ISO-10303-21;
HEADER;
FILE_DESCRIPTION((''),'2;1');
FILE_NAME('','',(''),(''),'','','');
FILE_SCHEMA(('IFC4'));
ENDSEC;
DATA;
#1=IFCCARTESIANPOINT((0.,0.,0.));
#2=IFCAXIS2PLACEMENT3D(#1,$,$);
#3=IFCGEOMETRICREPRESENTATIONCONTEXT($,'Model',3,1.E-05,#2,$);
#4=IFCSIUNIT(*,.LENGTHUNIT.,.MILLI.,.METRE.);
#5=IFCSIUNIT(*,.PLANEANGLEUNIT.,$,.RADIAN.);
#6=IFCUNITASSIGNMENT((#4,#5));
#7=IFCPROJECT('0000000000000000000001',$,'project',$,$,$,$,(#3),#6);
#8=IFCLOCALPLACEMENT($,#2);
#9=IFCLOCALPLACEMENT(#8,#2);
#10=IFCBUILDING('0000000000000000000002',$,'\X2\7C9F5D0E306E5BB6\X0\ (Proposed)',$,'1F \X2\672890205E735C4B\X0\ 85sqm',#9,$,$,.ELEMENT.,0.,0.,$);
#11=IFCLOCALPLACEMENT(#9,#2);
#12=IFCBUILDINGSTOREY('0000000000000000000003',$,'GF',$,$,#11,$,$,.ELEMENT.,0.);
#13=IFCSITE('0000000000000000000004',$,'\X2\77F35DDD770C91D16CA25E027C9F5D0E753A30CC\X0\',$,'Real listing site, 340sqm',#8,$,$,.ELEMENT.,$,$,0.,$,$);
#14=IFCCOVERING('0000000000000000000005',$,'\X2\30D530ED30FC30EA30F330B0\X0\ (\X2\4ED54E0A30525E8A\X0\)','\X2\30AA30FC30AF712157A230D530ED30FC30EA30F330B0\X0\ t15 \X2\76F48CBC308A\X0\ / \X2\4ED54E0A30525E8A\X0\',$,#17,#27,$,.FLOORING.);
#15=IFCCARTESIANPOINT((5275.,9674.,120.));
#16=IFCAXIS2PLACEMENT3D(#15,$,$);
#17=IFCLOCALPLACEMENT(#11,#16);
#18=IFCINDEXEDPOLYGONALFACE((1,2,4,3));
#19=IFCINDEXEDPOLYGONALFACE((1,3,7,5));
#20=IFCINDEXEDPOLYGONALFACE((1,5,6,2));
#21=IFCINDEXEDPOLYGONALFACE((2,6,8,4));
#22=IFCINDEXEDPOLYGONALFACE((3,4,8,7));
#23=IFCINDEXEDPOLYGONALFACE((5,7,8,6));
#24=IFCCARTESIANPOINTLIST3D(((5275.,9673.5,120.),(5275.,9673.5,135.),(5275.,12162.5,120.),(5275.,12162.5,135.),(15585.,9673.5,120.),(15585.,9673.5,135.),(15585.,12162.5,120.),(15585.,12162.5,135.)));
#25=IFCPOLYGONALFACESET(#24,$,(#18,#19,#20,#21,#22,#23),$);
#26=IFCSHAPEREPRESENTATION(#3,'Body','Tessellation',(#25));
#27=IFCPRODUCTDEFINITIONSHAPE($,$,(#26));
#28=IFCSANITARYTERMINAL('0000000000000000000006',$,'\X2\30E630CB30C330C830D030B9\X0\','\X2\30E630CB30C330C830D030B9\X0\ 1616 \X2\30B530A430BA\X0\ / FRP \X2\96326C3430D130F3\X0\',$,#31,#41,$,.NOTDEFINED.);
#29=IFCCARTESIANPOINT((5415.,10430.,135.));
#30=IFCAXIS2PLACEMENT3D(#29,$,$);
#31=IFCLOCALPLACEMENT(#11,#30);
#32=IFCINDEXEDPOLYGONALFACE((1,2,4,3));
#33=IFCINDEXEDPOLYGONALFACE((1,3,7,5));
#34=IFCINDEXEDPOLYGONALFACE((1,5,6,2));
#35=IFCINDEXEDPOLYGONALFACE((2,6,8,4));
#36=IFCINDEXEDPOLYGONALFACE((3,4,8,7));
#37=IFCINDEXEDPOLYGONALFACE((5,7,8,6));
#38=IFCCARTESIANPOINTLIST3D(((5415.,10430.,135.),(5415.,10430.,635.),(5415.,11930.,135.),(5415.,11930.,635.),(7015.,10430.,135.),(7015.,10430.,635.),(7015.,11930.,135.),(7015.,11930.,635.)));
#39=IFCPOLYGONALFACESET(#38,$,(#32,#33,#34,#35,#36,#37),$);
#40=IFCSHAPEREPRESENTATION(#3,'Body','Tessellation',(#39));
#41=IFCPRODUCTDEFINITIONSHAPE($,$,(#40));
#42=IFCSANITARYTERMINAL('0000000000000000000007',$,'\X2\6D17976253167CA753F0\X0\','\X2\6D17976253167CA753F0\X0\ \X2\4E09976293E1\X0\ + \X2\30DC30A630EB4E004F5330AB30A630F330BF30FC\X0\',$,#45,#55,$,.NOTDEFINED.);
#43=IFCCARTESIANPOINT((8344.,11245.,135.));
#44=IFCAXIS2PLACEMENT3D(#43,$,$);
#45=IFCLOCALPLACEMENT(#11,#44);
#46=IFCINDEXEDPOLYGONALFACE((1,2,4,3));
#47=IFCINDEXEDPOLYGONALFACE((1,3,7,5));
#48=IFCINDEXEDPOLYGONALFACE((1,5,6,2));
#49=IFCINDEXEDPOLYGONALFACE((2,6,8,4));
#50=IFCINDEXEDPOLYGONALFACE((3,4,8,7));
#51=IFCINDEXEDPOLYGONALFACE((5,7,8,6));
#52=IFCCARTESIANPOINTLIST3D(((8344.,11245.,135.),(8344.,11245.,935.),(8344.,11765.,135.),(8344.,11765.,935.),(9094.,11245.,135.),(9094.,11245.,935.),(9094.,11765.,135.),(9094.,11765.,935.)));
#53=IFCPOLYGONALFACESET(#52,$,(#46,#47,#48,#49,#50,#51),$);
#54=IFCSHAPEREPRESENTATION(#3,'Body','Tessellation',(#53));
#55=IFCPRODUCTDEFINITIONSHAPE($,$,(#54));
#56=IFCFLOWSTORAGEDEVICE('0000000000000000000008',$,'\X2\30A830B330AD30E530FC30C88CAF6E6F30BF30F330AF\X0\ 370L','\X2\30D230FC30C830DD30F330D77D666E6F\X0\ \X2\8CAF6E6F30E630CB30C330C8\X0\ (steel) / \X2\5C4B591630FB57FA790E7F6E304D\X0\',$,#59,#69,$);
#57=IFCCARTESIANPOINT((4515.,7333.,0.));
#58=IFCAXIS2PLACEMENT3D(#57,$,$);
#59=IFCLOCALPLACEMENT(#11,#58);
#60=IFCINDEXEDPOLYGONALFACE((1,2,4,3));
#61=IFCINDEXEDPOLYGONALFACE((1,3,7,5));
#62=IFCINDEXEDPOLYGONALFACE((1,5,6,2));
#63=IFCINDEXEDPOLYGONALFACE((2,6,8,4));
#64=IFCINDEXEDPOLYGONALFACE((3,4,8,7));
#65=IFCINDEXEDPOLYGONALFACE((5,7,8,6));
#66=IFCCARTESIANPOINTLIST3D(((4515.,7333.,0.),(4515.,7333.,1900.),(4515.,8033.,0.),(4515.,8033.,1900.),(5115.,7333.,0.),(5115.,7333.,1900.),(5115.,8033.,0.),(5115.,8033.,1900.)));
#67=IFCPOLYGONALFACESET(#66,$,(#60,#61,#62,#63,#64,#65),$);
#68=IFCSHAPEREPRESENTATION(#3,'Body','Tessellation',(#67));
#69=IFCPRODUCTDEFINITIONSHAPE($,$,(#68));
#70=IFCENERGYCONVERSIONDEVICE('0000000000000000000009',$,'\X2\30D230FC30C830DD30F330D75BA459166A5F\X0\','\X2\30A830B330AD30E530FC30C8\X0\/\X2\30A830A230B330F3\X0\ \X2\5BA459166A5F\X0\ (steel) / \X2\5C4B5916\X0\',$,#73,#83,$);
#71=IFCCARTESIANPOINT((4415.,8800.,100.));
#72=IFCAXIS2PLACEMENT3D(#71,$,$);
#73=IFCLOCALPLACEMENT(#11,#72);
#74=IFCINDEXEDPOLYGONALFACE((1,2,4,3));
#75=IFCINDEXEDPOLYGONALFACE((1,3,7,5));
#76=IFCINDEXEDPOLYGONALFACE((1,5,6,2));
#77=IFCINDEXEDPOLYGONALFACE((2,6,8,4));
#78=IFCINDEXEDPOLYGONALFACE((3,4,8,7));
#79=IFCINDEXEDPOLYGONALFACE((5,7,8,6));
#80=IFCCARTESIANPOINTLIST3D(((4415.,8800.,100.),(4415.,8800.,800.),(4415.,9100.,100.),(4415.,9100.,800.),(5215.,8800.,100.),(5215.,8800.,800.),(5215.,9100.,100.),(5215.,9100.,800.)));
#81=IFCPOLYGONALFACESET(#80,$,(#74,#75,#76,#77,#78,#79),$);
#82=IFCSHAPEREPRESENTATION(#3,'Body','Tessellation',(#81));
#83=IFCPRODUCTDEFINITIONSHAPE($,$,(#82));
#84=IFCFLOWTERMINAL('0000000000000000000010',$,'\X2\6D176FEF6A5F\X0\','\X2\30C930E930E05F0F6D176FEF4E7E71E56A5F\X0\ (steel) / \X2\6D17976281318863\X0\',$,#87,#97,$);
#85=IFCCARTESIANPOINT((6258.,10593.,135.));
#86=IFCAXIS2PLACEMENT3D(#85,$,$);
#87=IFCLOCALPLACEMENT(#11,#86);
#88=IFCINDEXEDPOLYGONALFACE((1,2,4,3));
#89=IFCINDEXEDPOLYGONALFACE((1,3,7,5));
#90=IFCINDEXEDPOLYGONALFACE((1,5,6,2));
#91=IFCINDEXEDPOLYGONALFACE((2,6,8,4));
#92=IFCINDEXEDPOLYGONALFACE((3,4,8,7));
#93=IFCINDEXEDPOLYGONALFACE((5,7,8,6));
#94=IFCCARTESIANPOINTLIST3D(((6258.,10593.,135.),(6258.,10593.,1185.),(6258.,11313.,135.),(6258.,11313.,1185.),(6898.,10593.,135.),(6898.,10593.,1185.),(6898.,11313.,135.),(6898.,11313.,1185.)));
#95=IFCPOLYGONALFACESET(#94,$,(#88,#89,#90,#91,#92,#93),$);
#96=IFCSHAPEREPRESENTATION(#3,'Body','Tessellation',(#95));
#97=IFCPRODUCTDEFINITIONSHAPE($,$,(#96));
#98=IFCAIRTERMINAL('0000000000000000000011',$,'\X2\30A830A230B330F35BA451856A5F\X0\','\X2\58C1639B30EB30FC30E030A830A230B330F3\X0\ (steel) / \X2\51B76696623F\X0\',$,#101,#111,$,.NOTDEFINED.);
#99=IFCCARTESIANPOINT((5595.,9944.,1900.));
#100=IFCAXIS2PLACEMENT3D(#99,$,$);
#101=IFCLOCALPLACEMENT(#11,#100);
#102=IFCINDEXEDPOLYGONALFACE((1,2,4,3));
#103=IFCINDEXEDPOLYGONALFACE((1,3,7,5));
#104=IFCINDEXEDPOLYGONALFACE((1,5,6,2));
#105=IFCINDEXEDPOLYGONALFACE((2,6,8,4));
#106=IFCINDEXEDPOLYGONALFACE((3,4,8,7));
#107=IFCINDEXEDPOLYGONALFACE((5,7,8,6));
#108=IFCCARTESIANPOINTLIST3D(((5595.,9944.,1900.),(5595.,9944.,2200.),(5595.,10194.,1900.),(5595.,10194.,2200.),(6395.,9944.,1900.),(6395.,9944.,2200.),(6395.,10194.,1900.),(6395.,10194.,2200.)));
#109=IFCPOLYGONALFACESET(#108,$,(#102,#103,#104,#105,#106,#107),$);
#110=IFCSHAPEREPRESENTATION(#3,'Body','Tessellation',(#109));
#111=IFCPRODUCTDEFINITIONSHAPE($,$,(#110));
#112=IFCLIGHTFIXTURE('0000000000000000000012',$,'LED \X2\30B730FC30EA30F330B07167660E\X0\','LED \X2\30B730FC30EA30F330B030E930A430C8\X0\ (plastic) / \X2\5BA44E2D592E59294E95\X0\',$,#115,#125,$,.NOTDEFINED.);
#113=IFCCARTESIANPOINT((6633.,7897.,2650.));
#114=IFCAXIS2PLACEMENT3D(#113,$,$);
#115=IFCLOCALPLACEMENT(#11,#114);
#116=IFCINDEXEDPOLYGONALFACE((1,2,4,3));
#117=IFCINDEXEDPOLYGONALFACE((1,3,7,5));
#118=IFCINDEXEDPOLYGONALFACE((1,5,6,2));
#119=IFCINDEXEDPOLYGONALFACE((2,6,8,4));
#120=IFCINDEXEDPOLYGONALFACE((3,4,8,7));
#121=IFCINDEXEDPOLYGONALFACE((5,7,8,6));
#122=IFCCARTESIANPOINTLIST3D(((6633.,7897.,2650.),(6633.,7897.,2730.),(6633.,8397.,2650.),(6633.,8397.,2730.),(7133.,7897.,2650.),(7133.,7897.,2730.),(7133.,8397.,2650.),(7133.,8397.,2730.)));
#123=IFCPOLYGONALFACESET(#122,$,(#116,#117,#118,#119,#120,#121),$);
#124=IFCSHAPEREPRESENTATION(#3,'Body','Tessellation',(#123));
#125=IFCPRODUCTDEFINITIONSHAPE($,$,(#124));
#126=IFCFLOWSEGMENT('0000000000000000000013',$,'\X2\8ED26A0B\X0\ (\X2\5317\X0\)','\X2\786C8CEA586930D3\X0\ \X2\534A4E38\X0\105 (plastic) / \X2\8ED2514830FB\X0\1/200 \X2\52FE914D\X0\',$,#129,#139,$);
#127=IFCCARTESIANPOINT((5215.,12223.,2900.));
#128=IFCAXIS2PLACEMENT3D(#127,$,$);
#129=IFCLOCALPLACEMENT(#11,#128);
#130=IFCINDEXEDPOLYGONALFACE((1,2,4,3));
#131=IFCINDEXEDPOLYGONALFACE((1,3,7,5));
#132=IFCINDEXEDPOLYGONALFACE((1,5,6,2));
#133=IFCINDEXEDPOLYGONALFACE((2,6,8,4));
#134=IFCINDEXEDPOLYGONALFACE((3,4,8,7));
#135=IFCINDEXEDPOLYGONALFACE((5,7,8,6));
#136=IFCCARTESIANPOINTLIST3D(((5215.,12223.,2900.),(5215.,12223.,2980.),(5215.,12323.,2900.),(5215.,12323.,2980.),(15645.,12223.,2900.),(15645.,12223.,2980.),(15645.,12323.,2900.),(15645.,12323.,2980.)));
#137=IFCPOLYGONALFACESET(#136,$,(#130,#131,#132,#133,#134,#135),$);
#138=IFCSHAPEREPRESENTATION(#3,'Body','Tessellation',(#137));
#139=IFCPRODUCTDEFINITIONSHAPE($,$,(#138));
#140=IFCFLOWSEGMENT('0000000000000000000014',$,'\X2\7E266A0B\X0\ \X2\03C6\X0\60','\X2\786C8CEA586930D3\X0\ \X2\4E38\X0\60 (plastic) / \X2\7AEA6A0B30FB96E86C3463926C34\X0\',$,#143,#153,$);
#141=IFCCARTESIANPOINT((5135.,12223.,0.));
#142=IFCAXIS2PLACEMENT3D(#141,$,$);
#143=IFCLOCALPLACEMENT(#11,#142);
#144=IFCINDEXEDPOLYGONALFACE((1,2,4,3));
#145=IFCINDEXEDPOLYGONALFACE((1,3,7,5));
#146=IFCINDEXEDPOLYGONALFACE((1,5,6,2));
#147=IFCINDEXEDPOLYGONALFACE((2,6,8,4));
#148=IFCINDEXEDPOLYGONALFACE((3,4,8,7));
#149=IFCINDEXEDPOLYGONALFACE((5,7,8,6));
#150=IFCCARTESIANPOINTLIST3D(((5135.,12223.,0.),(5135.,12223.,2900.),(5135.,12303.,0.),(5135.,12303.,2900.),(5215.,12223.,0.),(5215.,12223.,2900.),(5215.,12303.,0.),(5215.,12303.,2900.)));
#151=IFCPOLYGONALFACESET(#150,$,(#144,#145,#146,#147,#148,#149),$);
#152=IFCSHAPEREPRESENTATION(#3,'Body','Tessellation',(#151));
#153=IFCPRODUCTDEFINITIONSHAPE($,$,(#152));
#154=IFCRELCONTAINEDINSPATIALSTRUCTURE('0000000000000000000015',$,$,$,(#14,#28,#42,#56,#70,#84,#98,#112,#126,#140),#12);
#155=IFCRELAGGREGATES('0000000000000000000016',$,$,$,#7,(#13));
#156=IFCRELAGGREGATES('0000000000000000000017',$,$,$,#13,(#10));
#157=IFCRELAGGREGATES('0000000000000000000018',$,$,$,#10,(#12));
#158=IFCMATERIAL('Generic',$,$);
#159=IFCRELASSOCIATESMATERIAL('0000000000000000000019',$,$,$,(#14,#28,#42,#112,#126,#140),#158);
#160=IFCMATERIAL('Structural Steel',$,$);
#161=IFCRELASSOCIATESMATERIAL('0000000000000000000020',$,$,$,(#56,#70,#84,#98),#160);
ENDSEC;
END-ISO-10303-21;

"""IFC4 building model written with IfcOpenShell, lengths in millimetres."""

from ifc_helpers import new_model, si_unit, frame, frame_2d, origin, place, context, project, spatial, rectangle, extrude, material, element, save


model = new_model("IFC4")

# Units and contexts
model_context = context("Model", 3, precision=1e-05, world=origin())
ifc_project = project(units=[si_unit("LENGTHUNIT", "METRE", prefix="MILLI"), si_unit("PLANEANGLEUNIT", "RADIAN")], contexts=[model_context])

# Site, building, storey
site_placement = place(None, origin())
site = spatial("IfcSite", under=ifc_project, at=site_placement, Name="石川県金沢市粟崎町ヌ", ObjectType="Real listing site, 340sqm", CompositionType="ELEMENT", RefElevation=0.0)
building_placement = place(site_placement, origin())
building = spatial("IfcBuilding", under=site, at=building_placement, Name="粟崎の家 (Proposed)", ObjectType="1F 木造平屋 85sqm", CompositionType="ELEMENT", ElevationOfRefHeight=0.0, ElevationOfTerrain=0.0)
storey_placement = place(building_placement, origin())
storey = spatial("IfcBuildingStorey", under=building, at=storey_placement, Name="GF", CompositionType="ELEMENT", Elevation=0.0)

# Shared definitions
ifc_material_1 = material(Name="Structural Steel")

# Covering
ifc_material_2 = material(Name="Generic")
covering_1_placement = place(storey_placement, frame((5275.0, 9674.0, 120.0)))
element("IfcCovering", 1, at=covering_1_placement, inside=storey, material=ifc_material_2, Name="フローリング (仕上げ床)", Description="オーク無垢フローリング t15 直貼り / 仕上げ床", PredefinedType="FLOORING", context=model_context, shape_type="SweptSolid", body=[
    extrude(rectangle(XDim=10310.0, YDim=2489.0, at=frame_2d((5155.0, 1244.0))), frame((5275.0, 9674.0, 120.0)), (0.0, 0.0, 1.0), 15.0),
])

# Sanitary terminals
sanitary_terminal_1_placement = place(storey_placement, frame((5415.0, 10430.0, 135.0)))
element("IfcSanitaryTerminal", 2, at=sanitary_terminal_1_placement, inside=storey, material=ifc_material_2, Name="ユニットバス", Description="ユニットバス 1616 サイズ / FRP 防水パン", PredefinedType="NOTDEFINED", context=model_context, shape_type="SweptSolid", body=[
    extrude(rectangle(XDim=1600.0, YDim=1500.0, at=frame_2d((800.0, 750.0))), frame((5415.0, 10430.0, 135.0)), (0.0, 0.0, 1.0), 500.0),
])
sanitary_terminal_2_placement = place(storey_placement, frame((8344.0, 11245.0, 135.0)))
element("IfcSanitaryTerminal", 3, at=sanitary_terminal_2_placement, inside=storey, material=ifc_material_2, Name="洗面化粧台", Description="洗面化粧台 三面鏡 + ボウル一体カウンター", PredefinedType="NOTDEFINED", context=model_context, shape_type="SweptSolid", body=[
    extrude(rectangle(XDim=750.0, YDim=520.0, at=frame_2d((375.0, 260.0))), frame((8344.0, 11245.0, 135.0)), (0.0, 0.0, 1.0), 800.0),
])

# Flow storage device
flow_storage_device_placement = place(storey_placement, frame((4515.0, 7333.0, 0.0)))
element("IfcFlowStorageDevice", 4, at=flow_storage_device_placement, inside=storey, material=ifc_material_1, Name="エコキュート貯湯タンク 370L", Description="ヒートポンプ給湯 貯湯ユニット (steel) / 屋外・基礎置き", context=model_context, shape_type="SweptSolid", body=[
    extrude(rectangle(XDim=600.0, YDim=700.0, at=frame_2d((300.0, 350.0))), frame((4515.0, 7333.0, 0.0)), (0.0, 0.0, 1.0), 1900.0),
])

# Energy conversion device
energy_conversion_device_placement = place(storey_placement, frame((4415.0, 8800.0, 100.0)))
element("IfcEnergyConversionDevice", 5, at=energy_conversion_device_placement, inside=storey, material=ifc_material_1, Name="ヒートポンプ室外機", Description="エコキュート/エアコン 室外機 (steel) / 屋外", context=model_context, shape_type="SweptSolid", body=[
    extrude(rectangle(XDim=800.0, YDim=300.0, at=frame_2d((400.0, 150.0))), frame((4415.0, 8800.0, 100.0)), (0.0, 0.0, 1.0), 700.0),
])

# Flow terminal
flow_terminal_placement = place(storey_placement, frame((6258.0, 10593.0, 135.0)))
element("IfcFlowTerminal", 6, at=flow_terminal_placement, inside=storey, material=ifc_material_1, Name="洗濯機", Description="ドラム式洗濯乾燥機 (steel) / 洗面脱衣", context=model_context, shape_type="SweptSolid", body=[
    extrude(rectangle(XDim=640.0, YDim=720.0, at=frame_2d((320.0, 360.0))), frame((6258.0, 10593.0, 135.0)), (0.0, 0.0, 1.0), 1050.0),
])

# Air terminal
air_terminal_placement = place(storey_placement, frame((5595.0, 9944.0, 1900.0)))
element("IfcAirTerminal", 7, at=air_terminal_placement, inside=storey, material=ifc_material_1, Name="エアコン室内機", Description="壁掛ルームエアコン (steel) / 冷暖房", PredefinedType="NOTDEFINED", context=model_context, shape_type="SweptSolid", body=[
    extrude(rectangle(XDim=800.0, YDim=250.0, at=frame_2d((400.0, 125.0))), frame((5595.0, 9944.0, 1900.0)), (0.0, 0.0, 1.0), 300.0),
])

# Light fixture
light_fixture_placement = place(storey_placement, frame((6633.0, 7897.0, 2650.0)))
element("IfcLightFixture", 8, at=light_fixture_placement, inside=storey, material=ifc_material_2, Name="LED シーリング照明", Description="LED シーリングライト (plastic) / 室中央天井", PredefinedType="NOTDEFINED", context=model_context, shape_type="SweptSolid", body=[
    extrude(rectangle(XDim=500.0, YDim=500.0, at=frame_2d((250.0, 250.0))), frame((6633.0, 7897.0, 2650.0)), (0.0, 0.0, 1.0), 80.0),
])

# Flow segments
flow_segment_1_placement = place(storey_placement, frame((5215.0, 12223.0, 2900.0)))
element("IfcFlowSegment", 9, at=flow_segment_1_placement, inside=storey, material=ifc_material_2, Name="軒樋 (北)", Description="硬質塩ビ 半丸105 (plastic) / 軒先・1/200 勾配", context=model_context, shape_type="SweptSolid", body=[
    extrude(rectangle(XDim=10430.0, YDim=100.0, at=frame_2d((5215.0, 50.0))), frame((5215.0, 12223.0, 2900.0)), (0.0, 0.0, 1.0), 80.0),
])
flow_segment_2_placement = place(storey_placement, frame((5135.0, 12223.0, 0.0)))
element("IfcFlowSegment", 10, at=flow_segment_2_placement, inside=storey, material=ifc_material_2, Name="縦樋 φ60", Description="硬質塩ビ 丸60 (plastic) / 竪樋・雨水排水", context=model_context, shape_type="SweptSolid", body=[
    extrude(rectangle(XDim=80.0, YDim=80.0, at=frame_2d((40.0, 40.0))), frame((5135.0, 12223.0, 0.0)), (0.0, 0.0, 1.0), 2900.0),
])

save(model, "model.ifc")
